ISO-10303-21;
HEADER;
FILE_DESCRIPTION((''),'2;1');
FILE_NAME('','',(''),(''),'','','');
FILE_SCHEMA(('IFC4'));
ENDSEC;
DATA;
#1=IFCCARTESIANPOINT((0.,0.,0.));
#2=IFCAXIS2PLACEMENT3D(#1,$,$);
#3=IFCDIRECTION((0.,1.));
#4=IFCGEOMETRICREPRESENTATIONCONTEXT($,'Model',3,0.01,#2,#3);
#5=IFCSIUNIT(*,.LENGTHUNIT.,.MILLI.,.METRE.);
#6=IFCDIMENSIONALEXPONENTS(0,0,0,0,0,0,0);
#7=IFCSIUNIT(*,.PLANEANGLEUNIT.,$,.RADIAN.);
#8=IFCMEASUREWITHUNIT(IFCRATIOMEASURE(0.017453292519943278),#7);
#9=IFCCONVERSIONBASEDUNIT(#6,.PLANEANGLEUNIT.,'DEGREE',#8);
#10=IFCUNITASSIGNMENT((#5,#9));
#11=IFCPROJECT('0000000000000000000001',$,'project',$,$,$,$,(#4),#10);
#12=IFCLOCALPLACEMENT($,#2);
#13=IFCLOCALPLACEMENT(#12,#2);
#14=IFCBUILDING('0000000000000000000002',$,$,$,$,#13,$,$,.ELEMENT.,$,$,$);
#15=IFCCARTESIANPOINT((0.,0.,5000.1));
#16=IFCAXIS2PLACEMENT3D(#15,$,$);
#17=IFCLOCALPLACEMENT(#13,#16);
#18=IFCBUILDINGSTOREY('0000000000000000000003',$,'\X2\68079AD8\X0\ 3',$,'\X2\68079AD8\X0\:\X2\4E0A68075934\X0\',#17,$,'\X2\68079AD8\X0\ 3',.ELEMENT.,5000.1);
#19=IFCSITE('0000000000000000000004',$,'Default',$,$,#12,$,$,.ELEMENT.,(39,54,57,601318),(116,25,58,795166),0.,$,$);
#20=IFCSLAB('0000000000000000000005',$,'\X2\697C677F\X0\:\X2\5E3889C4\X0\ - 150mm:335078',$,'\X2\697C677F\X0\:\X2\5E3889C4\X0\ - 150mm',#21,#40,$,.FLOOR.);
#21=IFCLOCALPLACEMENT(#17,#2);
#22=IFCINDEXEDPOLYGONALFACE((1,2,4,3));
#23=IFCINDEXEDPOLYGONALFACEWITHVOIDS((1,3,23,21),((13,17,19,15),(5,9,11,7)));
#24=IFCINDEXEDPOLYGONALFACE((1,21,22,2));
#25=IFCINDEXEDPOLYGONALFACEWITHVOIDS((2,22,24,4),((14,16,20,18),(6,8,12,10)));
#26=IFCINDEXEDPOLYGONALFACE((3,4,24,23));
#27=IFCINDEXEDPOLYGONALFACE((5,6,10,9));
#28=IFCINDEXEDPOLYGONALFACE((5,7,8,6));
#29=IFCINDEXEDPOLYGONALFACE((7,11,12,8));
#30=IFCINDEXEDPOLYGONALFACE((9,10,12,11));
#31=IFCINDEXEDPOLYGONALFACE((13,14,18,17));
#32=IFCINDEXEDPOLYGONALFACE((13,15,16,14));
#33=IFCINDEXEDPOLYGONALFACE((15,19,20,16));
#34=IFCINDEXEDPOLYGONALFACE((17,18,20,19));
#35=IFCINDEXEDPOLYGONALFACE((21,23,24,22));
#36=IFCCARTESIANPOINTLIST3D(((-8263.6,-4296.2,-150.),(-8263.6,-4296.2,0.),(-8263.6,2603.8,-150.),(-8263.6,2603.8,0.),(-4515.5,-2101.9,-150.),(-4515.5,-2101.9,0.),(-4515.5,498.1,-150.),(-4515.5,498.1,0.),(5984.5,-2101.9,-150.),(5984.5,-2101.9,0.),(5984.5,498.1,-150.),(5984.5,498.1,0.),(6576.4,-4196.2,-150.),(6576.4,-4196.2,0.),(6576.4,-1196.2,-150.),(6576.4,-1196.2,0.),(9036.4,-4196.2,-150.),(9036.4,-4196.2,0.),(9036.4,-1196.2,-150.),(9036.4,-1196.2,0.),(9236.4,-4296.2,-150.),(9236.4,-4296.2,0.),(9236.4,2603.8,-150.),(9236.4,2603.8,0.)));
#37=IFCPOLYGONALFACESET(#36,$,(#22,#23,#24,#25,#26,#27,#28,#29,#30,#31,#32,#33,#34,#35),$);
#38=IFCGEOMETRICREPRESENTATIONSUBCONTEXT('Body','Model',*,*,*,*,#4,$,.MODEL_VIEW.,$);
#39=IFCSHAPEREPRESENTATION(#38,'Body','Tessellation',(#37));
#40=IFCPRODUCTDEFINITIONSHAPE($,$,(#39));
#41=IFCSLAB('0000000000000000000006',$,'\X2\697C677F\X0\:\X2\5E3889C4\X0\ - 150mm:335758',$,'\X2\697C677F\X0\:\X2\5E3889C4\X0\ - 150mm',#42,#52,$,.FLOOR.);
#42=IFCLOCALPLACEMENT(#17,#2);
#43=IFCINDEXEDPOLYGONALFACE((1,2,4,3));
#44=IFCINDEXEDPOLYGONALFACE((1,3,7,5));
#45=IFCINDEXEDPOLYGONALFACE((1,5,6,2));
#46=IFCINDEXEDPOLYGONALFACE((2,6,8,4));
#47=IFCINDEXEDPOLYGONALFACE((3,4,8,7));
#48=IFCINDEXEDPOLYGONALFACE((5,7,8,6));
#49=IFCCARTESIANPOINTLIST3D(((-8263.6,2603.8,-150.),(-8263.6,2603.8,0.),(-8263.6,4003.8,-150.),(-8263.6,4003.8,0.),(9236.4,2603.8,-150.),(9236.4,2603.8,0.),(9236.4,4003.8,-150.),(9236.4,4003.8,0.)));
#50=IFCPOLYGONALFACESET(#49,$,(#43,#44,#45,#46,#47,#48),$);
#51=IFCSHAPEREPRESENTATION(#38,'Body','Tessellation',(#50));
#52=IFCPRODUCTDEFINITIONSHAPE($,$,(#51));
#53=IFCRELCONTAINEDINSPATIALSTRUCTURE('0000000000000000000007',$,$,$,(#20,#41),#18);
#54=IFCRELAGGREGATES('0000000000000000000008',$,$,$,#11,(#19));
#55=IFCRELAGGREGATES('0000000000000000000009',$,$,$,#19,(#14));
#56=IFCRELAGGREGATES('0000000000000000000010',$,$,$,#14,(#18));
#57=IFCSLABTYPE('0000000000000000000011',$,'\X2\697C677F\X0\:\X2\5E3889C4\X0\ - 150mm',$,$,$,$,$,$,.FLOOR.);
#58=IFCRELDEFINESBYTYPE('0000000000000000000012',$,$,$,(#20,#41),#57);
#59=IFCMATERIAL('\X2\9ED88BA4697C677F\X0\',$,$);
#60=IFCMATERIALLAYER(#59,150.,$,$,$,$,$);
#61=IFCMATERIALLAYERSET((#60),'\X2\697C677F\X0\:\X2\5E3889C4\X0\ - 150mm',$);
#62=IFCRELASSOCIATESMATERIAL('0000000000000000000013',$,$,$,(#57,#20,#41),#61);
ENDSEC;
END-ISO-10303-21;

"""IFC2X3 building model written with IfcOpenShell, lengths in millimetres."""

from ifc_helpers import new_model, entity, si_unit, converted_unit, direction, frame, frame_2d, origin, origin_2d_with_axis, place, context, subcontext, project, spatial, rectangle, extrude, material, layer, layer_set, layer_usage, type_object, element, save


model = new_model("IFC2X3")

# Units and contexts
model_context = context("Model", 3, precision=0.01, world=origin(), true_north=direction((0.0, 1.0)))
body_context = subcontext(model_context, "Body", "Model", "MODEL_VIEW")
ifc_project = project(units=[si_unit("LENGTHUNIT", "METRE", prefix="MILLI"), converted_unit("PLANEANGLEUNIT", "DEGREE", entity("IfcRatioMeasure", 0.017453292519943278), si_unit("PLANEANGLEUNIT", "RADIAN"), dimensions=[0, 0, 0, 0, 0, 0, 0])], contexts=[model_context])

# Site, building, storey
site_placement = place(None, origin())
site = spatial("IfcSite", under=ifc_project, at=site_placement, Name="Default", CompositionType="ELEMENT", RefLatitude=(39, 54, 57, 601318), RefLongitude=(116, 25, 58, 795166), RefElevation=0.0)
building_placement = place(site_placement, origin())
building = spatial("IfcBuilding", under=site, at=building_placement, CompositionType="ELEMENT")
storey_placement = place(building_placement, frame((0.0, 0.0, 5000.1)))
storey = spatial("IfcBuildingStorey", under=building, at=storey_placement, Name="标高 3", ObjectType="标高:上标头", LongName="标高 3", CompositionType="ELEMENT", Elevation=5000.1)

# Slab, openings
ifc_material = material(Name="默认楼板")
ifc_layer = layer(ifc_material, 150.0)
ifc_layer_set = layer_set([ifc_layer], Name="楼板:常规 - 150mm")
ifc_layer_usage = layer_usage(ifc_layer_set, "AXIS3", "POSITIVE", 0.0)
slab_type = type_object("IfcSlabType", Name="楼板:常规 - 150mm", PredefinedType="FLOOR", material=ifc_layer_set)
slab_1_placement = place(storey_placement, frame((-8263.6, -4296.2, -150.0)))
slab_1 = element("IfcSlab", 1, at=slab_1_placement, inside=storey, type_object=slab_type, material=ifc_layer_usage, Name="楼板:常规 - 150mm:335078", ObjectType="楼板:常规 - 150mm", PredefinedType="FLOOR", context=body_context, shape_type="SweptSolid", body=[
    extrude(rectangle(XDim=6900.0, YDim=17500.0, at=frame_2d((0.0, 0.0), x_axis=(0.0, -1.0))), frame((8750.0, 3450.0, 150.0), z_axis=(0.0, 0.0, -1.0), x_axis=(-1.0, 0.0, 0.0)), (0.0, 0.0, 1.0), 150.0),
])
opening_1_placement = place(slab_1_placement, origin())
element("IfcOpeningElement", 2, at=opening_1_placement, cuts=slab_1, ObjectType="Opening", context=body_context, shape_type="SweptSolid", body=[
    extrude(rectangle(XDim=2460.0, YDim=3000.0, at=frame_2d((0.0, 0.0), x_axis=(1.0, 0.0))), frame((16070.0, 1600.0, 0.0), z_axis=(0.0, 0.0, 1.0), x_axis=(-1.0, 0.0, 0.0)), (0.0, 0.0, 1.0), 150.0),
])
opening_2_placement = place(slab_1_placement, origin())
element("IfcOpeningElement", 3, at=opening_2_placement, cuts=slab_1, ObjectType="Opening", context=body_context, shape_type="SweptSolid", body=[
    extrude(rectangle(XDim=2600.0, YDim=10500.0, at=origin_2d_with_axis()), frame((8998.1, 3494.3, 150.0), z_axis=(0.0, 0.0, 1.0), x_axis=(0.0, -1.0, 0.0)), (0.0, 0.0, -1.0), 150.0),
])

# Slab
slab_2_placement = place(storey_placement, origin())
element("IfcSlab", 4, at=slab_2_placement, inside=storey, type_object=slab_type, material=ifc_layer_usage, Name="楼板:常规 - 150mm:335758", ObjectType="楼板:常规 - 150mm", PredefinedType="FLOOR", context=body_context, shape_type="SweptSolid", body=[
    extrude(rectangle(XDim=1400.0, YDim=17500.0, at=frame_2d((0.0, 0.0), x_axis=(1.0, 0.0))), frame((486.4, 3303.8, 0.0), z_axis=(0.0, 0.0, -1.0), x_axis=(0.0, 1.0, 0.0)), (0.0, 0.0, 1.0), 150.0),
])

save(model, "model.ifc")
